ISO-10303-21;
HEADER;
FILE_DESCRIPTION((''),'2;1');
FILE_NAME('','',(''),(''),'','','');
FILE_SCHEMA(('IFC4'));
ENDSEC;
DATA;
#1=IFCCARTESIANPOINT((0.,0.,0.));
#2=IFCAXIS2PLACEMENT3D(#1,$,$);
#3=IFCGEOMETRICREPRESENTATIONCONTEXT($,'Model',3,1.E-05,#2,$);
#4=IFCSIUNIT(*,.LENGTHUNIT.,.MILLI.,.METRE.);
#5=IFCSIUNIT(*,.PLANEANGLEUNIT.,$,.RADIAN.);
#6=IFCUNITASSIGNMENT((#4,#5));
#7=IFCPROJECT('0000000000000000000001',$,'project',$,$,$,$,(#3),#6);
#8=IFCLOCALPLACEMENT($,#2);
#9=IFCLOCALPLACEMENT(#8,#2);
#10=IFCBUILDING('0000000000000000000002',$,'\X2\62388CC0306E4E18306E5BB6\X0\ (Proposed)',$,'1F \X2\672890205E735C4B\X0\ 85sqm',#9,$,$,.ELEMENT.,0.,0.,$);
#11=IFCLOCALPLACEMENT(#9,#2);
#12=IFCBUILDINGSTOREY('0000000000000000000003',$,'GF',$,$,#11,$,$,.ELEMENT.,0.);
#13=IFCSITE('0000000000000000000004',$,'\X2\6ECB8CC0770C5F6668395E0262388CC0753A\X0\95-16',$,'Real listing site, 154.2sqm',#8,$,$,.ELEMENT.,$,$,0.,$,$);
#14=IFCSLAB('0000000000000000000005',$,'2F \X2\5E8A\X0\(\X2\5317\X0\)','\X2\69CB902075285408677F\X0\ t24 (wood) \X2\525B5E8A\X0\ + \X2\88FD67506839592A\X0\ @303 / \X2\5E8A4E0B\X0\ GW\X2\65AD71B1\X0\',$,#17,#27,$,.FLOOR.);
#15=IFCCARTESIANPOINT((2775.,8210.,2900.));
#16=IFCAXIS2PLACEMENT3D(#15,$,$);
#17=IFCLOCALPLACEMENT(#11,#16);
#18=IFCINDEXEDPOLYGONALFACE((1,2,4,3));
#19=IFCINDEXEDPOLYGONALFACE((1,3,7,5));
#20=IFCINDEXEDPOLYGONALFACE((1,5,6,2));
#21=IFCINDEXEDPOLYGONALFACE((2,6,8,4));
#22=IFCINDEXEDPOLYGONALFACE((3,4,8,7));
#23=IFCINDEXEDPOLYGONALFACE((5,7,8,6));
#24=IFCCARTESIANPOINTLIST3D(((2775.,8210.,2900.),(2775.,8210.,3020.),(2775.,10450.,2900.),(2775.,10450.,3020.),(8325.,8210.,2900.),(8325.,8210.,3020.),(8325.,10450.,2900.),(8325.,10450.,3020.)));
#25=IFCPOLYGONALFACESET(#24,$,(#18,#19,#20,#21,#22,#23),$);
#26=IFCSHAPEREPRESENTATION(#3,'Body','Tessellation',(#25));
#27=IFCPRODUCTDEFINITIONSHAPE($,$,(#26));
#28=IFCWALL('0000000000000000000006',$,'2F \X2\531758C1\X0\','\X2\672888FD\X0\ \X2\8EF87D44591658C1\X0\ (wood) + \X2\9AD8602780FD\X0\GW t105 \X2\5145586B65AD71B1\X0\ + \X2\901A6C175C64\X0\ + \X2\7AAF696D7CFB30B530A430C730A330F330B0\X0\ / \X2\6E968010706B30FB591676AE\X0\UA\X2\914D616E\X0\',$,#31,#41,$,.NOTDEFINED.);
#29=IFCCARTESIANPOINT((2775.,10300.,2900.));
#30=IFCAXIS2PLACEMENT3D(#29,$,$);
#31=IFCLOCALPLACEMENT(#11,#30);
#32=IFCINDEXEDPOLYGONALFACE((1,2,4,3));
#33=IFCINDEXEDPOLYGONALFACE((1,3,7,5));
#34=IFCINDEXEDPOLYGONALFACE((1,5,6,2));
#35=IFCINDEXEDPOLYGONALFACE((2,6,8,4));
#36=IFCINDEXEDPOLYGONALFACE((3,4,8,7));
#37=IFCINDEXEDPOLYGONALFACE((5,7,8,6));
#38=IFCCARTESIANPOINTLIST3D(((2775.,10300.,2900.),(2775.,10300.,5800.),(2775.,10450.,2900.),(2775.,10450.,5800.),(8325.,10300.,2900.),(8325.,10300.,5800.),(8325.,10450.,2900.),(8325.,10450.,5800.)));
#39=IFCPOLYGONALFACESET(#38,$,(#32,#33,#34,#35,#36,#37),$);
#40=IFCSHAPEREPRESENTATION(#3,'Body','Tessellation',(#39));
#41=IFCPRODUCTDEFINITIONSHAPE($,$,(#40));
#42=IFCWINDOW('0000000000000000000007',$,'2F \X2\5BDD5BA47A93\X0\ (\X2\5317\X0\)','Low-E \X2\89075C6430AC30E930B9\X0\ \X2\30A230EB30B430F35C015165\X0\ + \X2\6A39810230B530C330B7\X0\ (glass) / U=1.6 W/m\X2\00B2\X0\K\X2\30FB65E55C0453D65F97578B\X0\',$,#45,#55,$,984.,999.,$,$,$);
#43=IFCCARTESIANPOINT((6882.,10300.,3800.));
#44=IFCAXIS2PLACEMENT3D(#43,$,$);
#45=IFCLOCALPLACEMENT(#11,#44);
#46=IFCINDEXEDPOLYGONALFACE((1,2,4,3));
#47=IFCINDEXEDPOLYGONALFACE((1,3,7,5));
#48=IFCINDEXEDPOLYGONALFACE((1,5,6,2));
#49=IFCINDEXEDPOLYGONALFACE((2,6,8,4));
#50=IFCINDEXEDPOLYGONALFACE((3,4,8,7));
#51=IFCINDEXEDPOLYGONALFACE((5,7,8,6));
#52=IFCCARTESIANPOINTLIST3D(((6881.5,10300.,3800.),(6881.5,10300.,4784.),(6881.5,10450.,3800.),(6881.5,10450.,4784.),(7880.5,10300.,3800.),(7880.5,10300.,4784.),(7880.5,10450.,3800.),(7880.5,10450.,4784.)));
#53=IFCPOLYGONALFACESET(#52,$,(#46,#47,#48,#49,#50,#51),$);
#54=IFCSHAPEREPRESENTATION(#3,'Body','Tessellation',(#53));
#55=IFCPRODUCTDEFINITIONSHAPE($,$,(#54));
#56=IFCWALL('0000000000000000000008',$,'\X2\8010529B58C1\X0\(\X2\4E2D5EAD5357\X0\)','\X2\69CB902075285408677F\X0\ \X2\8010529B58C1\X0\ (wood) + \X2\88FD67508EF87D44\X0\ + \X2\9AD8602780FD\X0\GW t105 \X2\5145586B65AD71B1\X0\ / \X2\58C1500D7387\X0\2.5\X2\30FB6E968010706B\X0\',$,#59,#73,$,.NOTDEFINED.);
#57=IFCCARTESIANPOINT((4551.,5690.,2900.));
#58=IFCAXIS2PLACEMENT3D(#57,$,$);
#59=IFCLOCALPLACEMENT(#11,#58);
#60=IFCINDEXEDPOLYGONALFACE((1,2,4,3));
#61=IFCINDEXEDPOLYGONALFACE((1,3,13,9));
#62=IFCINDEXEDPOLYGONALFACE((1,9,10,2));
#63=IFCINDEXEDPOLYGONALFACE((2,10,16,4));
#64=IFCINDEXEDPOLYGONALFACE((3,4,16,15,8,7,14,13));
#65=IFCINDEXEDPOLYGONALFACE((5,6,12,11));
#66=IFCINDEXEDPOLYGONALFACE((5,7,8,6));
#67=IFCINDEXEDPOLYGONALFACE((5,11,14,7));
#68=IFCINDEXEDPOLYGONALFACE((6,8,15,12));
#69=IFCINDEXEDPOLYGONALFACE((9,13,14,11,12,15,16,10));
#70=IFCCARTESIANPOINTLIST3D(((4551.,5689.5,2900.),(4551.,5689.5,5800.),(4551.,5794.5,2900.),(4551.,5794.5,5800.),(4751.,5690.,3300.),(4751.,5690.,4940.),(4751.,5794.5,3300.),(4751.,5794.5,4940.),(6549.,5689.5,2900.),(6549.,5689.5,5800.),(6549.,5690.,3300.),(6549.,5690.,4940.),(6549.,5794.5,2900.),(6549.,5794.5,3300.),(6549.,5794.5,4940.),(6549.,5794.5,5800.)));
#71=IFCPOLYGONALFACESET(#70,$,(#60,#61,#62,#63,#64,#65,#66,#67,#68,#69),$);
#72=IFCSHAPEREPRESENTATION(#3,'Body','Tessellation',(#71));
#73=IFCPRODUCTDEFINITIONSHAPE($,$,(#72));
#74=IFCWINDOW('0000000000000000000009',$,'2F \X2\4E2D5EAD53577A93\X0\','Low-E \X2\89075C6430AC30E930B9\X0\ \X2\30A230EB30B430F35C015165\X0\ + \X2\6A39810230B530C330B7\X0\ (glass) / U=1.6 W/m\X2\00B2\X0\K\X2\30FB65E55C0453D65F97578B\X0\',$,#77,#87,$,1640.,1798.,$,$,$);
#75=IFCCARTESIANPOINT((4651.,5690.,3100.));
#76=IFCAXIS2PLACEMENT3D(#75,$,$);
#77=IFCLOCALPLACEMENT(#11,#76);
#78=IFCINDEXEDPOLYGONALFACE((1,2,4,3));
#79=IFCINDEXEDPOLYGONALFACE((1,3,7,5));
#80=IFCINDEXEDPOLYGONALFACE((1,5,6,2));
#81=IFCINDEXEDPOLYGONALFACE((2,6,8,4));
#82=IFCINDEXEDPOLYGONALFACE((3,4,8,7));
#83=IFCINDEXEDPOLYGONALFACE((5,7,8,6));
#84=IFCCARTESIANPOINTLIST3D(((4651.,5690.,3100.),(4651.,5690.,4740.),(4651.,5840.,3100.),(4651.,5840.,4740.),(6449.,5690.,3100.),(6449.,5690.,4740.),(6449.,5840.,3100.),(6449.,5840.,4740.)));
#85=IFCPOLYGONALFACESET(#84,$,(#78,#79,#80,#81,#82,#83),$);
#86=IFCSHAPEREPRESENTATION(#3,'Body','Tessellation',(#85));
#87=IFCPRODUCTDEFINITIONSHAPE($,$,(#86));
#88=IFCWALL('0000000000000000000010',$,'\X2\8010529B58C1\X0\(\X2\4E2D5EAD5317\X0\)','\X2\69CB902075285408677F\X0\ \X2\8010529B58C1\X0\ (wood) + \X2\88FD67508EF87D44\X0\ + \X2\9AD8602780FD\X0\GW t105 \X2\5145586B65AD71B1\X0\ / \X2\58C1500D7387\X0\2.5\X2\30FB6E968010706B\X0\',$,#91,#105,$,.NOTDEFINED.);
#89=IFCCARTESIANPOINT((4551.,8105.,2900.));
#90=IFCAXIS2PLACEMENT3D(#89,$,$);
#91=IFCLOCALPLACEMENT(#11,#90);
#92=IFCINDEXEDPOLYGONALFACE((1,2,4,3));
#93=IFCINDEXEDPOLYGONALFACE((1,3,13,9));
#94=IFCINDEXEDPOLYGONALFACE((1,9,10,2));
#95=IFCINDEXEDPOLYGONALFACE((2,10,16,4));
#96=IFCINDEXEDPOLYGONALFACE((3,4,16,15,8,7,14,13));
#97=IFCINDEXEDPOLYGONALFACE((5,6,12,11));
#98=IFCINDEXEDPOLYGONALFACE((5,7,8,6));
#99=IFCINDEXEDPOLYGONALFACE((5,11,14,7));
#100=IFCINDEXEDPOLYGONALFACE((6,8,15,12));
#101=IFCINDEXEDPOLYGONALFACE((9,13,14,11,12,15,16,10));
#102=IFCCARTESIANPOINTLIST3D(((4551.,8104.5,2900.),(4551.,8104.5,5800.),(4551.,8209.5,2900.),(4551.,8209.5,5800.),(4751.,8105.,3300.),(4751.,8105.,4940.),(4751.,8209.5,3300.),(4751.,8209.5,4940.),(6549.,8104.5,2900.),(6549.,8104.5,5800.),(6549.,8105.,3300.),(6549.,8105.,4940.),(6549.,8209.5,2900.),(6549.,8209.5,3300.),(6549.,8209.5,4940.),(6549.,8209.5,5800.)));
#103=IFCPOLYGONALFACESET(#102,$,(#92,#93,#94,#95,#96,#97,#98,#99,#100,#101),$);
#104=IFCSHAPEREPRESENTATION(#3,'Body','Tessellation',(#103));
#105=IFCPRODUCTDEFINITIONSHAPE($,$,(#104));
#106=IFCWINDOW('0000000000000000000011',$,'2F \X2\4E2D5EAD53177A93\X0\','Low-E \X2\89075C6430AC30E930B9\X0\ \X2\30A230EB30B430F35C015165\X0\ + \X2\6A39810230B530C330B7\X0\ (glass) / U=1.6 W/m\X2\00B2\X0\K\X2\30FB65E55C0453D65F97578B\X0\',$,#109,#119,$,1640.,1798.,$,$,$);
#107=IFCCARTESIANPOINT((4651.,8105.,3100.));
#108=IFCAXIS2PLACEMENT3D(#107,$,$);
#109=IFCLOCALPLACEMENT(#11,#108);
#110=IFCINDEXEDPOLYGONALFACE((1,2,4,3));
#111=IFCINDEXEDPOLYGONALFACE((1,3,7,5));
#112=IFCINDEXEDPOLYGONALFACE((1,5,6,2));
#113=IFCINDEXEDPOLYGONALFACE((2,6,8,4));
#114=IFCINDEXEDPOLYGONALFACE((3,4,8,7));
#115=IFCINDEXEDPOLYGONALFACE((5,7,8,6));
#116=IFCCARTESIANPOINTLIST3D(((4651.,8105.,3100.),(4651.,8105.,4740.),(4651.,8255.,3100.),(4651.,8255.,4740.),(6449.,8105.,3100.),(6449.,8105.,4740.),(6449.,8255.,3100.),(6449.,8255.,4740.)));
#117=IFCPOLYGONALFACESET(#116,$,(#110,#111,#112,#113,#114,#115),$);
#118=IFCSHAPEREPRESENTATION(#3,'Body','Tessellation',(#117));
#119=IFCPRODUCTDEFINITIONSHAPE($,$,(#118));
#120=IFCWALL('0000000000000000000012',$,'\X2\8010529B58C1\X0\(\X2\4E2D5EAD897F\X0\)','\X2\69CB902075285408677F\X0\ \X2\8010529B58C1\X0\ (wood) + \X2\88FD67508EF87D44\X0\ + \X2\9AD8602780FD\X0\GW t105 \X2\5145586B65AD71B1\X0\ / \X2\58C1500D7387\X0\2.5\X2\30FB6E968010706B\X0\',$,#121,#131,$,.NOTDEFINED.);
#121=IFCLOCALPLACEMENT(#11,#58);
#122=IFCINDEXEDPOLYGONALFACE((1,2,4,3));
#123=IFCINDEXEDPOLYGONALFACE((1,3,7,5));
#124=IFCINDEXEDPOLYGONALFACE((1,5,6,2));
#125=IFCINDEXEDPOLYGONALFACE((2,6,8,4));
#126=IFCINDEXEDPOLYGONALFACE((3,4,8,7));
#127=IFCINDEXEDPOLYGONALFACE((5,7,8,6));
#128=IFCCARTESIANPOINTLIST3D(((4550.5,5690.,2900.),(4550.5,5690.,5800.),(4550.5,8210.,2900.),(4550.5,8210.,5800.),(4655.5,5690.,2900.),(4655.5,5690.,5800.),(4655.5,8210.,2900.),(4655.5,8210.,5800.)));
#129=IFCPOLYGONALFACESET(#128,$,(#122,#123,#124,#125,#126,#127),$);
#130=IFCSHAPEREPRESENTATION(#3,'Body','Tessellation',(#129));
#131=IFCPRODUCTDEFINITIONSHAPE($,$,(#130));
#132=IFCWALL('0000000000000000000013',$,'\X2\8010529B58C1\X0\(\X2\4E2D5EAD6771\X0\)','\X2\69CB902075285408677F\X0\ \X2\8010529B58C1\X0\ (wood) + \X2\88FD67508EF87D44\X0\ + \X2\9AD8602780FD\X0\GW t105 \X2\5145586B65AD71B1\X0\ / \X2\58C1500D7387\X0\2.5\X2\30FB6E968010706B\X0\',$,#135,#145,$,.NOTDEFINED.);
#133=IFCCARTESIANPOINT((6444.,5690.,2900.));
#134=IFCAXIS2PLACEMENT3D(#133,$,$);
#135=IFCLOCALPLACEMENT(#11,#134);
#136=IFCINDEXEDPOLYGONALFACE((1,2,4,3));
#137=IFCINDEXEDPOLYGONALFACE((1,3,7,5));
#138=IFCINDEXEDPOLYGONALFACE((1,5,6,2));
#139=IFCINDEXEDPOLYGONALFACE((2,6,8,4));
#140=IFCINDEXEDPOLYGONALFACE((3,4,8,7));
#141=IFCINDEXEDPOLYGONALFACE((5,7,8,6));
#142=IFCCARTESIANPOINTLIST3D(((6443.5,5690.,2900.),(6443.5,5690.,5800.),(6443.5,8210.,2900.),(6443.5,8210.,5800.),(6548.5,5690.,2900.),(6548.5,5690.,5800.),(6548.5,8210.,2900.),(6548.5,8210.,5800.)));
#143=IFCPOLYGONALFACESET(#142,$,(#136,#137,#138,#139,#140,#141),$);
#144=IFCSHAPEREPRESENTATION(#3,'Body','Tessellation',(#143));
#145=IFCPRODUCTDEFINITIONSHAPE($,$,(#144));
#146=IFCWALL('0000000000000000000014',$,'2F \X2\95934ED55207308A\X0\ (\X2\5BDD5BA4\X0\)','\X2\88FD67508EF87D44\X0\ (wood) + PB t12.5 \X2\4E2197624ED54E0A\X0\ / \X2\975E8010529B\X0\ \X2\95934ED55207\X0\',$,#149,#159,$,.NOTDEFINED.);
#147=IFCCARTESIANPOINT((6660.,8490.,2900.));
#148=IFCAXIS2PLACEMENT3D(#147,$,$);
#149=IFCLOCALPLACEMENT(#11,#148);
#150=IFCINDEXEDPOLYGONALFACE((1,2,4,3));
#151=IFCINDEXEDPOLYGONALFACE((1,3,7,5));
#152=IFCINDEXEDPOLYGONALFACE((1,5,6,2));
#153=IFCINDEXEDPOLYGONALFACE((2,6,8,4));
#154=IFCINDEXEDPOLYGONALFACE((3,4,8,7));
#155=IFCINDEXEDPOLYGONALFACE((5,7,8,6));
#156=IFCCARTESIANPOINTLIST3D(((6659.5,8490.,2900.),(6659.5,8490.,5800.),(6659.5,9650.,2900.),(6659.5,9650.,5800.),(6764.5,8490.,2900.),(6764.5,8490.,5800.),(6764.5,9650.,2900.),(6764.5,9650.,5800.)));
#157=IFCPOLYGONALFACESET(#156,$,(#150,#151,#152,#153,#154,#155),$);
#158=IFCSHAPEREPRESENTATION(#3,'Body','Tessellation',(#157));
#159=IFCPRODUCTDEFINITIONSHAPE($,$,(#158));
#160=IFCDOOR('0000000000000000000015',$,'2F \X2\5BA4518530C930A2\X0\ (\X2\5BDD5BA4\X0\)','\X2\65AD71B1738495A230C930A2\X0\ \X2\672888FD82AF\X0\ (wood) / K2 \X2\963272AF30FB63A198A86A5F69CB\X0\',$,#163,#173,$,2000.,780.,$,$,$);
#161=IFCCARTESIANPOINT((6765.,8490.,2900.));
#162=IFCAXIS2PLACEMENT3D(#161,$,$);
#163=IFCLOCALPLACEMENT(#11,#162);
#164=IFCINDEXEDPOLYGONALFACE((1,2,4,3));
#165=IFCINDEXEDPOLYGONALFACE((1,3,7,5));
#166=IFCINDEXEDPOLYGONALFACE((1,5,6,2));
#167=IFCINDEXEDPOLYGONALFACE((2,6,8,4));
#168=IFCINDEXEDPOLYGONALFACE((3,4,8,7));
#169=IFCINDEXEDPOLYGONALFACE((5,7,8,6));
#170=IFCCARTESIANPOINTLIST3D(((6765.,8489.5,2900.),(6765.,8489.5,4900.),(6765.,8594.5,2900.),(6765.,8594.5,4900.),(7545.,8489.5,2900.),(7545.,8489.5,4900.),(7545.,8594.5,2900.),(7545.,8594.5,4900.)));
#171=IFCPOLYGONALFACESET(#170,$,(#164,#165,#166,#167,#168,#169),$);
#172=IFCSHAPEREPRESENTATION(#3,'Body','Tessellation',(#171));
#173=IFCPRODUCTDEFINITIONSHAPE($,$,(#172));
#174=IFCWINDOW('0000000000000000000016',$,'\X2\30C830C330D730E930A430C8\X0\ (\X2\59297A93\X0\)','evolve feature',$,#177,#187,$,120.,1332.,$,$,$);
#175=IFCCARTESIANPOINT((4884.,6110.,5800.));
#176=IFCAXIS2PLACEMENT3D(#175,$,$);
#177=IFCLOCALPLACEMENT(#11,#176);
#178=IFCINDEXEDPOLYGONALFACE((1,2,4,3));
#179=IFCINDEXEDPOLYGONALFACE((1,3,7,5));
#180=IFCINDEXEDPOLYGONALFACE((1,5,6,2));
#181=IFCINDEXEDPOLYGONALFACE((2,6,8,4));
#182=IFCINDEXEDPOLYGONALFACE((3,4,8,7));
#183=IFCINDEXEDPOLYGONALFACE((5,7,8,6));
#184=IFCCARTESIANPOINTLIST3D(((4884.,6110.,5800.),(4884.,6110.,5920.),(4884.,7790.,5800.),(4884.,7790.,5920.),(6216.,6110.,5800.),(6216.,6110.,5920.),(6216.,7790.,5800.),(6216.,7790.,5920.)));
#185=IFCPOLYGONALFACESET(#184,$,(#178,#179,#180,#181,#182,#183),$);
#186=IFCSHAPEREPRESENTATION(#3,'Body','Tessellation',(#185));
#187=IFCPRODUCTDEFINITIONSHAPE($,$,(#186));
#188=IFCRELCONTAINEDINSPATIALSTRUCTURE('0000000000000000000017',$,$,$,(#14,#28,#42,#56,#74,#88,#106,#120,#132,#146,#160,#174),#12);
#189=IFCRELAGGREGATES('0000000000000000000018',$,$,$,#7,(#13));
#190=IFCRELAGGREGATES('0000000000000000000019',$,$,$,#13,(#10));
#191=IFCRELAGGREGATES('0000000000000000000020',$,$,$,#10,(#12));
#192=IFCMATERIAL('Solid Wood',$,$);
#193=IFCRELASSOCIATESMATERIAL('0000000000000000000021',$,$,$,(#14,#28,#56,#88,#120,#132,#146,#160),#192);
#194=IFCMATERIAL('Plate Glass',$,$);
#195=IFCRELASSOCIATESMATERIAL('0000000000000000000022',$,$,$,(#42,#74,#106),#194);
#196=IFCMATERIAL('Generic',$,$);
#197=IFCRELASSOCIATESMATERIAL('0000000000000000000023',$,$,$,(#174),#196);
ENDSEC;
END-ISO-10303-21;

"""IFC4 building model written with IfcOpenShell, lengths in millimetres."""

from ifc_helpers import new_model, si_unit, frame, frame_2d, origin, place, context, project, spatial, rectangle, extrude, material, element, fill, save


model = new_model("IFC4")

# Units and contexts
model_context = context("Model", 3, precision=1e-05, world=origin())
ifc_project = project(units=[si_unit("LENGTHUNIT", "METRE", prefix="MILLI"), si_unit("PLANEANGLEUNIT", "RADIAN")], contexts=[model_context])

# Site, building, storey
site_placement = place(None, origin())
site = spatial("IfcSite", under=ifc_project, at=site_placement, Name="滋賀県彦根市戸賀町95-16", ObjectType="Real listing site, 154.2sqm", CompositionType="ELEMENT", RefElevation=0.0)
building_placement = place(site_placement, origin())
building = spatial("IfcBuilding", under=site, at=building_placement, Name="戸賀の丘の家 (Proposed)", ObjectType="1F 木造平屋 85sqm", CompositionType="ELEMENT", ElevationOfRefHeight=0.0, ElevationOfTerrain=0.0)
storey_placement = place(building_placement, origin())
storey = spatial("IfcBuildingStorey", under=building, at=storey_placement, Name="GF", CompositionType="ELEMENT", Elevation=0.0)

# Slab
ifc_material_1 = material(Name="Solid Wood")
slab_placement = place(storey_placement, frame((2775.0, 8210.0, 2900.0)))
element("IfcSlab", 1, at=slab_placement, inside=storey, material=ifc_material_1, Name="2F 床(北)", Description="構造用合板 t24 (wood) 剛床 + 製材根太 @303 / 床下 GW断熱", PredefinedType="FLOOR", context=model_context, shape_type="SweptSolid", body=[
    extrude(rectangle(XDim=5550.0, YDim=2240.0, at=frame_2d((2775.0, 1120.0))), frame((2775.0, 8210.0, 2900.0)), (0.0, 0.0, 1.0), 120.0),
])

# Walls, openings, windows
wall_1_placement = place(storey_placement, frame((2775.0, 10300.0, 2900.0)))
wall_1 = element("IfcWall", 2, at=wall_1_placement, inside=storey, material=ifc_material_1, Name="2F 北壁", Description="木製 軸組外壁 (wood) + 高性能GW t105 充填断熱 + 通気層 + 窯業系サイディング / 準耐火・外皮UA配慮", PredefinedType="NOTDEFINED", context=model_context, shape_type="SweptSolid", body=[
    extrude(rectangle(XDim=5550.0, YDim=150.0, at=frame_2d((2775.0, 75.0))), frame((2775.0, 10300.0, 2900.0)), (0.0, 0.0, 1.0), 2900.0),
])
opening_1_placement = place(storey_placement, frame((6882.0, 10300.0, 3800.0)))
opening_1 = element("IfcOpeningElement", 3, at=opening_1_placement, cuts=wall_1, PredefinedType="NOTDEFINED", context=model_context, shape_type="SweptSolid", body=[
    extrude(rectangle(XDim=999.0, YDim=150.0, at=frame_2d((499.0, 75.0))), frame((6882.0, 10300.0, 3800.0)), (0.0, 0.0, 1.0), 984.0),
])
ifc_material_2 = material(Name="Plate Glass")
window_1_placement = place(storey_placement, frame((6882.0, 10300.0, 3800.0)))
window_1 = element("IfcWindow", 4, at=window_1_placement, inside=storey, material=ifc_material_2, Name="2F 寝室窓 (北)", Description="Low-E 複層ガラス アルゴン封入 + 樹脂サッシ (glass) / U=1.6 W/m²K・日射取得型", OverallHeight=984.0, OverallWidth=999.0, context=model_context, shape_type="SweptSolid", body=[
    extrude(rectangle(XDim=999.0, YDim=150.0, at=frame_2d((499.0, 75.0))), frame((6882.0, 10300.0, 3800.0)), (0.0, 0.0, 1.0), 984.0),
])
fill(opening_1, window_1)
wall_2_placement = place(storey_placement, frame((4551.0, 5690.0, 2900.0)))
wall_2 = element("IfcWall", 5, at=wall_2_placement, inside=storey, material=ifc_material_1, Name="耐力壁(中庭南)", Description="構造用合板 耐力壁 (wood) + 製材軸組 + 高性能GW t105 充填断熱 / 壁倍率2.5・準耐火", PredefinedType="NOTDEFINED", context=model_context, shape_type="SweptSolid", body=[
    extrude(rectangle(XDim=1998.0, YDim=105.0, at=frame_2d((999.0, 52.0))), frame((4551.0, 5690.0, 2900.0)), (0.0, 0.0, 1.0), 2900.0),
])
opening_2_placement = place(storey_placement, frame((4651.0, 5690.0, 3100.0)))
opening_2 = element("IfcOpeningElement", 6, at=opening_2_placement, cuts=wall_2, PredefinedType="NOTDEFINED", context=model_context, shape_type="SweptSolid", body=[
    extrude(rectangle(XDim=1798.0, YDim=150.0, at=frame_2d((899.0, 75.0))), frame((4651.0, 5690.0, 3100.0)), (0.0, 0.0, 1.0), 1640.0),
])
window_2_placement = place(storey_placement, frame((4651.0, 5690.0, 3100.0)))
window_2 = element("IfcWindow", 7, at=window_2_placement, inside=storey, material=ifc_material_2, Name="2F 中庭南窓", Description="Low-E 複層ガラス アルゴン封入 + 樹脂サッシ (glass) / U=1.6 W/m²K・日射取得型", OverallHeight=1640.0, OverallWidth=1798.0, context=model_context, shape_type="SweptSolid", body=[
    extrude(rectangle(XDim=1798.0, YDim=150.0, at=frame_2d((899.0, 75.0))), frame((4651.0, 5690.0, 3100.0)), (0.0, 0.0, 1.0), 1640.0),
])
fill(opening_2, window_2)
wall_3_placement = place(storey_placement, frame((4551.0, 8105.0, 2900.0)))
wall_3 = element("IfcWall", 8, at=wall_3_placement, inside=storey, material=ifc_material_1, Name="耐力壁(中庭北)", Description="構造用合板 耐力壁 (wood) + 製材軸組 + 高性能GW t105 充填断熱 / 壁倍率2.5・準耐火", PredefinedType="NOTDEFINED", context=model_context, shape_type="SweptSolid", body=[
    extrude(rectangle(XDim=1998.0, YDim=105.0, at=frame_2d((999.0, 52.0))), frame((4551.0, 8105.0, 2900.0)), (0.0, 0.0, 1.0), 2900.0),
])
opening_3_placement = place(storey_placement, frame((4651.0, 8105.0, 3100.0)))
opening_3 = element("IfcOpeningElement", 9, at=opening_3_placement, cuts=wall_3, PredefinedType="NOTDEFINED", context=model_context, shape_type="SweptSolid", body=[
    extrude(rectangle(XDim=1798.0, YDim=150.0, at=frame_2d((899.0, 75.0))), frame((4651.0, 8105.0, 3100.0)), (0.0, 0.0, 1.0), 1640.0),
])
window_3_placement = place(storey_placement, frame((4651.0, 8105.0, 3100.0)))
window_3 = element("IfcWindow", 10, at=window_3_placement, inside=storey, material=ifc_material_2, Name="2F 中庭北窓", Description="Low-E 複層ガラス アルゴン封入 + 樹脂サッシ (glass) / U=1.6 W/m²K・日射取得型", OverallHeight=1640.0, OverallWidth=1798.0, context=model_context, shape_type="SweptSolid", body=[
    extrude(rectangle(XDim=1798.0, YDim=150.0, at=frame_2d((899.0, 75.0))), frame((4651.0, 8105.0, 3100.0)), (0.0, 0.0, 1.0), 1640.0),
])
fill(opening_3, window_3)

# Walls
wall_4_placement = place(storey_placement, frame((4551.0, 5690.0, 2900.0)))
element("IfcWall", 11, at=wall_4_placement, inside=storey, material=ifc_material_1, Name="耐力壁(中庭西)", Description="構造用合板 耐力壁 (wood) + 製材軸組 + 高性能GW t105 充填断熱 / 壁倍率2.5・準耐火", PredefinedType="NOTDEFINED", context=model_context, shape_type="SweptSolid", body=[
    extrude(rectangle(XDim=105.0, YDim=2520.0, at=frame_2d((52.0, 1260.0))), frame((4551.0, 5690.0, 2900.0)), (0.0, 0.0, 1.0), 2900.0),
])
wall_5_placement = place(storey_placement, frame((6444.0, 5690.0, 2900.0)))
element("IfcWall", 12, at=wall_5_placement, inside=storey, material=ifc_material_1, Name="耐力壁(中庭東)", Description="構造用合板 耐力壁 (wood) + 製材軸組 + 高性能GW t105 充填断熱 / 壁倍率2.5・準耐火", PredefinedType="NOTDEFINED", context=model_context, shape_type="SweptSolid", body=[
    extrude(rectangle(XDim=105.0, YDim=2520.0, at=frame_2d((52.0, 1260.0))), frame((6444.0, 5690.0, 2900.0)), (0.0, 0.0, 1.0), 2900.0),
])
wall_6_placement = place(storey_placement, frame((6660.0, 8490.0, 2900.0)))
element("IfcWall", 13, at=wall_6_placement, inside=storey, material=ifc_material_1, Name="2F 間仕切り (寝室)", Description="製材軸組 (wood) + PB t12.5 両面仕上 / 非耐力 間仕切", PredefinedType="NOTDEFINED", context=model_context, shape_type="SweptSolid", body=[
    extrude(rectangle(XDim=105.0, YDim=1160.0, at=frame_2d((52.0, 580.0))), frame((6660.0, 8490.0, 2900.0)), (0.0, 0.0, 1.0), 2900.0),
])

# Door
door_placement = place(storey_placement, frame((6765.0, 8490.0, 2900.0)))
element("IfcDoor", 14, at=door_placement, inside=storey, material=ifc_material_1, Name="2F 室内ドア (寝室)", Description="断熱玄関ドア 木製芯 (wood) / K2 防犯・採風機構", OverallHeight=2000.0, OverallWidth=780.0, context=model_context, shape_type="SweptSolid", body=[
    extrude(rectangle(XDim=780.0, YDim=105.0, at=frame_2d((390.0, 52.0))), frame((6765.0, 8490.0, 2900.0)), (0.0, 0.0, 1.0), 2000.0),
])

# Window
ifc_material_3 = material(Name="Generic")
window_4_placement = place(storey_placement, frame((4884.0, 6110.0, 5800.0)))
element("IfcWindow", 15, at=window_4_placement, inside=storey, material=ifc_material_3, Name="トップライト (天窓)", Description="evolve feature", OverallHeight=120.0, OverallWidth=1332.0, context=model_context, shape_type="SweptSolid", body=[
    extrude(rectangle(XDim=1332.0, YDim=1680.0, at=frame_2d((666.0, 840.0))), frame((4884.0, 6110.0, 5800.0)), (0.0, 0.0, 1.0), 120.0),
])

save(model, "model.ifc")
